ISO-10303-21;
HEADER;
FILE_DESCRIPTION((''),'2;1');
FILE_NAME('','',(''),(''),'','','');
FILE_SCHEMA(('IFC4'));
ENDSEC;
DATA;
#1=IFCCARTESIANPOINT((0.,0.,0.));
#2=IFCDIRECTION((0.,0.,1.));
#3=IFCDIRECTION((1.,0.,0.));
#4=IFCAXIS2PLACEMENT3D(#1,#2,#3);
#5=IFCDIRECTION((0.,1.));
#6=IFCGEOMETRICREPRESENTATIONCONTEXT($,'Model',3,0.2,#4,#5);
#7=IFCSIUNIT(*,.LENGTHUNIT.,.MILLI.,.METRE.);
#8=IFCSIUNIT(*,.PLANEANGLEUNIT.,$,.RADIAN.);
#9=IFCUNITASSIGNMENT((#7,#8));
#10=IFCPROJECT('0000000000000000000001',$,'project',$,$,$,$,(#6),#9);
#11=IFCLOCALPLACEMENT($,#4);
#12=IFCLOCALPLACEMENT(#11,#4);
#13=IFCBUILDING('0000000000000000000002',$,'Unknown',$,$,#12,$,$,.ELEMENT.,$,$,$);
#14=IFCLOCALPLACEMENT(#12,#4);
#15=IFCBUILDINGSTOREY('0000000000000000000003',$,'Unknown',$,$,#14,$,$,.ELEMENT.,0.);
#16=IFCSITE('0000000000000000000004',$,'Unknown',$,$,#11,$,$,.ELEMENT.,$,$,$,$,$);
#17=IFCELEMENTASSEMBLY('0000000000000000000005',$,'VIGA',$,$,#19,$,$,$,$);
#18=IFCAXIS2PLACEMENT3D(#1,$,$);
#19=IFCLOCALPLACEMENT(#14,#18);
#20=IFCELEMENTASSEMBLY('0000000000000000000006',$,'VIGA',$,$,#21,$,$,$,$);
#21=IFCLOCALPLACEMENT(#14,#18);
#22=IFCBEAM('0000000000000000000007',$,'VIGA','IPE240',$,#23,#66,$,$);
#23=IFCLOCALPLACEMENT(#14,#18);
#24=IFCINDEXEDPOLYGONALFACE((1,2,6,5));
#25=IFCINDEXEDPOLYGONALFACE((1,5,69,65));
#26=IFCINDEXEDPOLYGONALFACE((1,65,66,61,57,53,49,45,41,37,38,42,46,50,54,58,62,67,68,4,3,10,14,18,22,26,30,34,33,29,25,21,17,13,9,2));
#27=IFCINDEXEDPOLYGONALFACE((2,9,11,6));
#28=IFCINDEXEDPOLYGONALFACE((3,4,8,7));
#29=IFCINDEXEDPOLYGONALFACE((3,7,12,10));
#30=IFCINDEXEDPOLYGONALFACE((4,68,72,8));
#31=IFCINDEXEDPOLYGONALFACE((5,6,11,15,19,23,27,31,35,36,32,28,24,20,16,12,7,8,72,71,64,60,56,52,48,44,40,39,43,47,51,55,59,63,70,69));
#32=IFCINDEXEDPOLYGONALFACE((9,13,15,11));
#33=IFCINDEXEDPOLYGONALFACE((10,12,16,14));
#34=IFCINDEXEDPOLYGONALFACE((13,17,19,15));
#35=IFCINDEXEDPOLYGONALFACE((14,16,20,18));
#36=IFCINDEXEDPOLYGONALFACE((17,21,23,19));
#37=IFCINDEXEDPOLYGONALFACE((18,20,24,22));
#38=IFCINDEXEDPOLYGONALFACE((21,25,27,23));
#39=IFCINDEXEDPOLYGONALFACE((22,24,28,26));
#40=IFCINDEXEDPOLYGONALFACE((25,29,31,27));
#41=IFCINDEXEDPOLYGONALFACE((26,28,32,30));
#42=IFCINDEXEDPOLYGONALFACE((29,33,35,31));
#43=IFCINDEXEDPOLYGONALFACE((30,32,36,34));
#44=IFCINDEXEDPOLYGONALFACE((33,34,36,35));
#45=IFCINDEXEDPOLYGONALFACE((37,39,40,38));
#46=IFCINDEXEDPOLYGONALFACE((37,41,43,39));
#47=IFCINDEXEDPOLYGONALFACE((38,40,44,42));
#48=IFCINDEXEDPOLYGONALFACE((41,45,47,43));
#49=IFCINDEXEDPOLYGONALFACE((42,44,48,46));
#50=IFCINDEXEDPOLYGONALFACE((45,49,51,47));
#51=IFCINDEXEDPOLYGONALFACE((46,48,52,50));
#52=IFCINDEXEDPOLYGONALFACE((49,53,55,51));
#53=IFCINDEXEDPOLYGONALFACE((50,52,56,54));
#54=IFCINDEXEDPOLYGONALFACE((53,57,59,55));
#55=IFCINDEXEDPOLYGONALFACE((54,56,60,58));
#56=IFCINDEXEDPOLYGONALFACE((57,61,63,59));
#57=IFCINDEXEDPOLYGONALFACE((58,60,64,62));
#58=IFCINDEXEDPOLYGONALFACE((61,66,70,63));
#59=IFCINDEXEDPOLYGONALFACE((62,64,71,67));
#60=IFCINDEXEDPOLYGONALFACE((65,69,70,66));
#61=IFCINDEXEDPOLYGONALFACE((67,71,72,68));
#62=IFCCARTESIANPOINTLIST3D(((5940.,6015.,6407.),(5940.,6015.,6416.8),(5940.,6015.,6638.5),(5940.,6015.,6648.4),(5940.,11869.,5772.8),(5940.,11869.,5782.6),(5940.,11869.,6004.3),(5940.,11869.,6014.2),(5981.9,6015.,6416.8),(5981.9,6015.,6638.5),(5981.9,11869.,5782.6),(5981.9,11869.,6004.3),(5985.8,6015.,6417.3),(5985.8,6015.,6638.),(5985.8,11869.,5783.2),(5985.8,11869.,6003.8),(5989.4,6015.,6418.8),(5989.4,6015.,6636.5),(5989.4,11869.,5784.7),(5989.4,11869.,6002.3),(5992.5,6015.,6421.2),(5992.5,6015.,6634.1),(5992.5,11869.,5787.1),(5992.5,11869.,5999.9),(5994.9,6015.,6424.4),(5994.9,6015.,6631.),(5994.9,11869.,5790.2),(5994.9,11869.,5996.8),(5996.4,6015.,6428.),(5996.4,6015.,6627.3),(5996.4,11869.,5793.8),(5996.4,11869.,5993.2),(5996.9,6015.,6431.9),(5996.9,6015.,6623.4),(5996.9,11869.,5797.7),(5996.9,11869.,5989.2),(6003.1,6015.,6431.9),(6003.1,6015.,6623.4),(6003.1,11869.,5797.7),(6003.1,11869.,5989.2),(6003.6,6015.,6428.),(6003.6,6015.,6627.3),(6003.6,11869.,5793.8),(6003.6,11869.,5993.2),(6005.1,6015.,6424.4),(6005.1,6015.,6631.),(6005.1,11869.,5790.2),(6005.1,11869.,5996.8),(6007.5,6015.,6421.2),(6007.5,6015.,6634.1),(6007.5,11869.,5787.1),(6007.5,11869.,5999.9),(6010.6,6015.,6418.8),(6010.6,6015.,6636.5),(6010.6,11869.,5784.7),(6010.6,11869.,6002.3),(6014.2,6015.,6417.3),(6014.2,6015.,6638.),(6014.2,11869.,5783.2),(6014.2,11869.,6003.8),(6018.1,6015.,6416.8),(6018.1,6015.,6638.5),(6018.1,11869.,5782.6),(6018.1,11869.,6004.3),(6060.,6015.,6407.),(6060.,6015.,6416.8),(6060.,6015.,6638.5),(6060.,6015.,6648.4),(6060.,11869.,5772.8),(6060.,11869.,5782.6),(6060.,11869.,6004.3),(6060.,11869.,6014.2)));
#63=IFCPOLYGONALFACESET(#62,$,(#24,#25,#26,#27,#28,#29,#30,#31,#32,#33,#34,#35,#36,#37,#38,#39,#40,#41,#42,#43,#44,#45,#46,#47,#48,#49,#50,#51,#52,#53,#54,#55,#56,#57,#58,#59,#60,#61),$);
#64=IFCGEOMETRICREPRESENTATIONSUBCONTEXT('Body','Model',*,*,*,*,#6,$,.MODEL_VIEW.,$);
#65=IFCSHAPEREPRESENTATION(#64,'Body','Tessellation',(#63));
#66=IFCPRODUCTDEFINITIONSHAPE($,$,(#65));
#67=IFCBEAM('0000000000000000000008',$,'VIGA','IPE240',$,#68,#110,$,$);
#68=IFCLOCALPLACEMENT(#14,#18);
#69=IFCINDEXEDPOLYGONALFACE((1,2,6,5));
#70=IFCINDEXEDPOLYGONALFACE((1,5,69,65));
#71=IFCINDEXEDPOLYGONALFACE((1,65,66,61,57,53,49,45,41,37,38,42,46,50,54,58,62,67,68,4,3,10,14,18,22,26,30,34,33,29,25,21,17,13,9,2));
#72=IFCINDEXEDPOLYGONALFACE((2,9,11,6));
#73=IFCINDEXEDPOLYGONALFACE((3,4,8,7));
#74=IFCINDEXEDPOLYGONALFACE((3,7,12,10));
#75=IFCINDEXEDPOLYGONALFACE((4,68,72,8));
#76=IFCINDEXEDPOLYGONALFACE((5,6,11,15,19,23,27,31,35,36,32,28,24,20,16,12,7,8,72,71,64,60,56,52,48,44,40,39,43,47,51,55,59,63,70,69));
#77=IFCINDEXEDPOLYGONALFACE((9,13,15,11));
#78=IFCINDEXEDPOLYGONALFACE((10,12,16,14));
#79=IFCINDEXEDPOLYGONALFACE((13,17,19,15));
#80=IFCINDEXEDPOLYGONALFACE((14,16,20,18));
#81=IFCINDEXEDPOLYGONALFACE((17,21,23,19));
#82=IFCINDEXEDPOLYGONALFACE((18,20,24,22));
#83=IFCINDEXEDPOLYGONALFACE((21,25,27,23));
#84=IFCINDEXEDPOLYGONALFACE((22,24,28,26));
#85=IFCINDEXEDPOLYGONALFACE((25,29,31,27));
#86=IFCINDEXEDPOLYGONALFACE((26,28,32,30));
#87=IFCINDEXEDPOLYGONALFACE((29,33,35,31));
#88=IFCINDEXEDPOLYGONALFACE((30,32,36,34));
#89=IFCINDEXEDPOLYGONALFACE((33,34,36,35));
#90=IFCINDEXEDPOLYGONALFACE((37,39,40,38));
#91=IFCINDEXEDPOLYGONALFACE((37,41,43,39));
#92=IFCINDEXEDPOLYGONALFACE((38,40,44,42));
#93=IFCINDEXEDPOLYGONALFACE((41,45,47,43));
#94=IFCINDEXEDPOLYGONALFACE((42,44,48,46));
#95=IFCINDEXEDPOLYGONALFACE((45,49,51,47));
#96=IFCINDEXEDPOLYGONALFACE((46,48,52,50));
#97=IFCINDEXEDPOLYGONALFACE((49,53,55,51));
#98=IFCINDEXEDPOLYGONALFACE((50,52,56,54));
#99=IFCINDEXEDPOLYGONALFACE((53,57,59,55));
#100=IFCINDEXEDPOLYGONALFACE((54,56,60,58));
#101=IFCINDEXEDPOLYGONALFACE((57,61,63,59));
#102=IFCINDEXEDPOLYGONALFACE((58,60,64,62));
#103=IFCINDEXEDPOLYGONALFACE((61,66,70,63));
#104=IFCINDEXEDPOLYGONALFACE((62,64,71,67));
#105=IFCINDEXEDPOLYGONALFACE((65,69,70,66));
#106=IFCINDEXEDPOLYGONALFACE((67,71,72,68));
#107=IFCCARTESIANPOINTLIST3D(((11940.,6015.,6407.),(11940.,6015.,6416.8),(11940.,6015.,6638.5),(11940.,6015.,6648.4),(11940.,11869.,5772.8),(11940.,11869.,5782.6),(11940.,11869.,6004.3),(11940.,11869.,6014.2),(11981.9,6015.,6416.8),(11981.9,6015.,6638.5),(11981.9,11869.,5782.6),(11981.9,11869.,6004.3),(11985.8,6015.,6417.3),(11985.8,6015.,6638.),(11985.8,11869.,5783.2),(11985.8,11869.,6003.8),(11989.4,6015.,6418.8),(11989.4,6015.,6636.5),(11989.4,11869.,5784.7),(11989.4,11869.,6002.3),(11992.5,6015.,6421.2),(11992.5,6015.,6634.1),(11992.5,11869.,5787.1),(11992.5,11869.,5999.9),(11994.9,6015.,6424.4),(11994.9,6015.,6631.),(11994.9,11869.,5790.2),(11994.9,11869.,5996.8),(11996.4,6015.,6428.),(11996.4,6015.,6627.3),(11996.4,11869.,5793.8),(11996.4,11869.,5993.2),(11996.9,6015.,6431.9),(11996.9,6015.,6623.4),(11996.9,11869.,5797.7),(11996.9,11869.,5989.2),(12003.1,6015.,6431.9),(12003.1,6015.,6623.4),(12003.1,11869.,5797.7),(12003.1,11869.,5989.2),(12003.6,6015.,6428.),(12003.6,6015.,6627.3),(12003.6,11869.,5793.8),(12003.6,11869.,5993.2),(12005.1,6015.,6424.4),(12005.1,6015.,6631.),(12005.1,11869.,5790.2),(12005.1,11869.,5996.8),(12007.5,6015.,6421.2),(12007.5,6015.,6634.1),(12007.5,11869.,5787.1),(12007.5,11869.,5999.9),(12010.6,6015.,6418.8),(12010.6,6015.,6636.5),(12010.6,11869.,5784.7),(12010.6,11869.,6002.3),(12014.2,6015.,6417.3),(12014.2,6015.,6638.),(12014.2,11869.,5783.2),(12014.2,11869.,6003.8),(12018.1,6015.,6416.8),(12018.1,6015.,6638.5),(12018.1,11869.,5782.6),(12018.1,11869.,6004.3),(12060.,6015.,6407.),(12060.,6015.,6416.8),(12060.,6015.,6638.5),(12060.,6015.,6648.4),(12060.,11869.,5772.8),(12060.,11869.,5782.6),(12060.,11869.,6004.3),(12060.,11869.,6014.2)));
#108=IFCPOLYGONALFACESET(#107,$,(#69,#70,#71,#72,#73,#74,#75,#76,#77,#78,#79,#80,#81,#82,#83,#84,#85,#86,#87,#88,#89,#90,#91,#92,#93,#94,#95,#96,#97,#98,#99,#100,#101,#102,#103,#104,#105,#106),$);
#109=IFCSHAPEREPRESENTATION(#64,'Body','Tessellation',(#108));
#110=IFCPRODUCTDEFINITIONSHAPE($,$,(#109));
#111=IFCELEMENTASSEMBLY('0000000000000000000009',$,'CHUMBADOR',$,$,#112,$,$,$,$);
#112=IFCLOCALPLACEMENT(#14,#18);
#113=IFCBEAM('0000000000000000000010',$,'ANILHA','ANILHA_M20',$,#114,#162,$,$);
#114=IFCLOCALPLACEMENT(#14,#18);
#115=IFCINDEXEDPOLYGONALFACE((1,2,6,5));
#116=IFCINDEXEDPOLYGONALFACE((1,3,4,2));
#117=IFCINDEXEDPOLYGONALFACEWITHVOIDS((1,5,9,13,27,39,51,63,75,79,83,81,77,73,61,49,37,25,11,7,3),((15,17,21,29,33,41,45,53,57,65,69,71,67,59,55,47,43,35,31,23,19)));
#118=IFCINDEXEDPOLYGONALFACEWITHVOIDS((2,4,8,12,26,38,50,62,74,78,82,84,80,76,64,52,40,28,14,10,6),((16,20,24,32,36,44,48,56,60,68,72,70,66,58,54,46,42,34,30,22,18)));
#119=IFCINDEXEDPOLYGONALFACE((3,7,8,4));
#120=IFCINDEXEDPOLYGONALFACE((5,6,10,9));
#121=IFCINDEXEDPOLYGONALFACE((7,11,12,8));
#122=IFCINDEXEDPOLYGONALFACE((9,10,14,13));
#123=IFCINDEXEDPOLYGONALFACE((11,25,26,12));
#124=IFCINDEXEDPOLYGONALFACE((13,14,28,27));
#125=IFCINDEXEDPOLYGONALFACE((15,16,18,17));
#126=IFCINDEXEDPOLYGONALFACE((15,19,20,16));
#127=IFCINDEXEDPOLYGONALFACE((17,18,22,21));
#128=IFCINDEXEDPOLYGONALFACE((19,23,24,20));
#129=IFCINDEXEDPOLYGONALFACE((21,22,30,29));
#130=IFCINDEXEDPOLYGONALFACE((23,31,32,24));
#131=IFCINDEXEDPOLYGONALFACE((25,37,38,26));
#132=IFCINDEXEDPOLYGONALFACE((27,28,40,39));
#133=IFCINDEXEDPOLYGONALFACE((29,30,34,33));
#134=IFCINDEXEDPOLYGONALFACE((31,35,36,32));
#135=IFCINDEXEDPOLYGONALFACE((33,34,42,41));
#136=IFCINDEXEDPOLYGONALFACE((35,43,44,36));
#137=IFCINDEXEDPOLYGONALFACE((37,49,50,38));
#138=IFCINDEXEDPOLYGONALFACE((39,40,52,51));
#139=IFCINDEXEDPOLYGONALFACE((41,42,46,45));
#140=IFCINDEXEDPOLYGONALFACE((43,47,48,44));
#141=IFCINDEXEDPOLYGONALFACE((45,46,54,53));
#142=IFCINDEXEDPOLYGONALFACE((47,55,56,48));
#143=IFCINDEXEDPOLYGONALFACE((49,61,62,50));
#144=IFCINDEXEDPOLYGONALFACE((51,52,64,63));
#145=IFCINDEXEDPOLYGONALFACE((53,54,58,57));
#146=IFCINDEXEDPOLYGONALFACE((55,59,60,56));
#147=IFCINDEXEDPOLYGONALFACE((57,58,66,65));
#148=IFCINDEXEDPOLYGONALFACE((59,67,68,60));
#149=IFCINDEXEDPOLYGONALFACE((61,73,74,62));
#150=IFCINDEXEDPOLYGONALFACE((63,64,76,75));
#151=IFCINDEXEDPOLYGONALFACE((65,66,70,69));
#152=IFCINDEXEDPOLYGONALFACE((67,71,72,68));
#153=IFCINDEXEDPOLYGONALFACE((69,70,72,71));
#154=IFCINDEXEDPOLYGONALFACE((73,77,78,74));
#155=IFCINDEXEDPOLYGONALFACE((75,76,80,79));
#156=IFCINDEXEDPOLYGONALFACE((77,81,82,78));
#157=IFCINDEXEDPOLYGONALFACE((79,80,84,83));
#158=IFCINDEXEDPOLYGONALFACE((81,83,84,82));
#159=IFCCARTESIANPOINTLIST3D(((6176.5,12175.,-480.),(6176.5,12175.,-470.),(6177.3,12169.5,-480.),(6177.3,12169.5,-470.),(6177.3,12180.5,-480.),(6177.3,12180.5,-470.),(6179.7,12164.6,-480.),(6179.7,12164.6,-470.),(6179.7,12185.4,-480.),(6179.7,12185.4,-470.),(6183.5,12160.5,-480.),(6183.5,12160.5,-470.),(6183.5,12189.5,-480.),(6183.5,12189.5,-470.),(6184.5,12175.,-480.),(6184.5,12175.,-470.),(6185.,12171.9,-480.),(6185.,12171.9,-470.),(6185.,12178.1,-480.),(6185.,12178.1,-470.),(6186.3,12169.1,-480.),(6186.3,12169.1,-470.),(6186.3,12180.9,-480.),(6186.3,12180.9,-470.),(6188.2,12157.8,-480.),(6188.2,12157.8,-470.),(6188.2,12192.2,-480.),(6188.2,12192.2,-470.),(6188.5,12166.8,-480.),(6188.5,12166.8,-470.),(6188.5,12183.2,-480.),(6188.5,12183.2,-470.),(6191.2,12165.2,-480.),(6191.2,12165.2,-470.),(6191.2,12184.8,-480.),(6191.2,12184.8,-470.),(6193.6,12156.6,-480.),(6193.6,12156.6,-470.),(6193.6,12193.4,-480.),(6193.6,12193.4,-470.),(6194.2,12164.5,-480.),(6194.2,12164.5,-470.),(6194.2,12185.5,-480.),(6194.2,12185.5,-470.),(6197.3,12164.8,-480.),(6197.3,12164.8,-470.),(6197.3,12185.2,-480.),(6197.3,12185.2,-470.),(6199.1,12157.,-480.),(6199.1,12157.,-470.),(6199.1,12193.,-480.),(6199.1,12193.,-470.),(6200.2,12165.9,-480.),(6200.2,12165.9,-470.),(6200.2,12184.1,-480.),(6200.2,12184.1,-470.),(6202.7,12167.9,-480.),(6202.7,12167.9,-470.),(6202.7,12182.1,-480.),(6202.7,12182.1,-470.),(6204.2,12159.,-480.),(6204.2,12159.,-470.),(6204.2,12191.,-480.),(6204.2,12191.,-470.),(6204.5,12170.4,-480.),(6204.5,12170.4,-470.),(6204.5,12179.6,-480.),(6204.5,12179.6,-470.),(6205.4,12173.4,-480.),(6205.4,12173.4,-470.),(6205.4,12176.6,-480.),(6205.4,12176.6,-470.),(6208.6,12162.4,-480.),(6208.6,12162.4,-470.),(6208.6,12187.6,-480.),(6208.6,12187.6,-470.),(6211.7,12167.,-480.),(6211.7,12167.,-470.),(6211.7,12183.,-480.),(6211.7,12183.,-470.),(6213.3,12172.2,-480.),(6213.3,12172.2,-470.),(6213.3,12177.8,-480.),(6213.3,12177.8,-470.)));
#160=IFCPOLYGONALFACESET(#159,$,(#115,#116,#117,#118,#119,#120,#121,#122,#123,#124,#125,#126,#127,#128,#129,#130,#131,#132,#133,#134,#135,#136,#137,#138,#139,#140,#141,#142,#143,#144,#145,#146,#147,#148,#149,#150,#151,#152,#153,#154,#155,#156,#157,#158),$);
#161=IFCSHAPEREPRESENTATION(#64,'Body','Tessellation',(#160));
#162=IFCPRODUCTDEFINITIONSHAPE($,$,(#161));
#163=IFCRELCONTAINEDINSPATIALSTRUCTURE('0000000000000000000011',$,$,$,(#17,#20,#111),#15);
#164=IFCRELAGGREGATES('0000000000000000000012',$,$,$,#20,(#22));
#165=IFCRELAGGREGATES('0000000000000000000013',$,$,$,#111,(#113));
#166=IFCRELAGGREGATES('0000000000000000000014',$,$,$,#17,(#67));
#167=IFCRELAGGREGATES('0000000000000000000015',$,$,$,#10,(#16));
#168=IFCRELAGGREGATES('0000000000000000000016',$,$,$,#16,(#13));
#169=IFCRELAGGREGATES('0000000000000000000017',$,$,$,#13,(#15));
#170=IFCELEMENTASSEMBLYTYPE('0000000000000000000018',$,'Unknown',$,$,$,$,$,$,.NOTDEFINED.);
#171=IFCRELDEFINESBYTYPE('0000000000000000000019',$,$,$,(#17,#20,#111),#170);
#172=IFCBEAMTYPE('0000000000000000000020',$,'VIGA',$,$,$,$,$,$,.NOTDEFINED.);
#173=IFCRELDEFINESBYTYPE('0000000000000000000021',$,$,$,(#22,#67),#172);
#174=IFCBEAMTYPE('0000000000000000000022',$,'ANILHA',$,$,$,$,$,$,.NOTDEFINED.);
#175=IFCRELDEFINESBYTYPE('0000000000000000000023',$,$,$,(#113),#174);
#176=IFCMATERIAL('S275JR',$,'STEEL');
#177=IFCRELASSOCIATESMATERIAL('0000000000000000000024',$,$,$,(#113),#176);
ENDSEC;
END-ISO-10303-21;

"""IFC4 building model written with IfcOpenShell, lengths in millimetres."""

from ifc_helpers import new_model, si_unit, direction, frame, origin_with_axes, origin_2d_with_axis, place, context, subcontext, project, spatial, hollow_circle, i_section, extrude, clip, halfspace, material, material_profile, profile_set, profile_usage, type_object, element, aggregate, save


model = new_model("IFC4")

# Units and contexts
model_context = context("Model", 3, precision=0.2, world=origin_with_axes(), true_north=direction((0.0, 1.0)))
body_context = subcontext(model_context, "Body", "Model", "MODEL_VIEW")
ifc_project = project(units=[si_unit("LENGTHUNIT", "METRE", prefix="MILLI"), si_unit("PLANEANGLEUNIT", "RADIAN")], contexts=[model_context])

# Site, building, storey
site_placement = place(None, origin_with_axes())
site = spatial("IfcSite", under=ifc_project, at=site_placement, Name="Unknown", CompositionType="ELEMENT")
building_placement = place(site_placement, origin_with_axes())
building = spatial("IfcBuilding", under=site, at=building_placement, Name="Unknown", CompositionType="ELEMENT")
storey_placement = place(building_placement, origin_with_axes())
storey = spatial("IfcBuildingStorey", under=building, at=storey_placement, Name="Unknown", CompositionType="ELEMENT", Elevation=0.0)

# Shared definitions
element_assembly_type = type_object("IfcElementAssemblyType", Name="Unknown", PredefinedType="NOTDEFINED")

# Element assemblies
assembly_1_placement = place(storey_placement, frame((12000.0, 11987.1, 5880.7), z_axis=(-1.0, 0.0, 0.0), x_axis=(0.0, -0.994183, 0.107703)))
assembly_1 = element("IfcElementAssembly", 1, at=assembly_1_placement, inside=storey, type_object=element_assembly_type, Name="VIGA")
assembly_2_placement = place(storey_placement, frame((6000.0, 11987.1, 5880.7), z_axis=(-1.0, 0.0, 0.0), x_axis=(0.0, -0.994183, 0.107703)))
assembly_2 = element("IfcElementAssembly", 2, at=assembly_2_placement, inside=storey, type_object=element_assembly_type, Name="VIGA")

# Beams
beam_type_1 = type_object("IfcBeamType", Name="VIGA", PredefinedType="NOTDEFINED")
beam_1_placement = place(assembly_2_placement, origin_with_axes())
beam_1 = element("IfcBeam", 3, at=beam_1_placement, type_object=beam_type_1, Name="VIGA", Description="IPE240", context=body_context, shape_type="Clipping", body=[
    clip(clip(extrude(i_section(OverallWidth=120.0, OverallDepth=240.0, WebThickness=6.2, FlangeThickness=9.8, FilletRadius=15.0, FlangeEdgeRadius=0.0, FlangeSlope=0.0, at=origin_2d_with_axis()), frame((-121.2, 0.0, 0.0), z_axis=(-1.0, 0.0, 0.0), x_axis=(0.0, 0.0, 1.0)), (0.0, 0.0, -1.0), 6368.3), halfspace(frame((105.8, -120.0, 0.0), z_axis=(0.994183, -0.107703, 0.0), x_axis=(0.107703, 0.994183, 0.0)), True)), halfspace(frame((6021.8, 136.5, 0.0), z_axis=(-0.994183, 0.107703, 0.0), x_axis=(-0.107703, -0.994183, 0.0)), True)),
])
aggregate(assembly_2, [beam_1])
beam_2_placement = place(assembly_1_placement, origin_with_axes())
beam_2 = element("IfcBeam", 4, at=beam_2_placement, type_object=beam_type_1, Name="VIGA", Description="IPE240", context=body_context, shape_type="Clipping", body=[
    clip(clip(extrude(i_section(OverallWidth=120.0, OverallDepth=240.0, WebThickness=6.2, FlangeThickness=9.8, FilletRadius=15.0, FlangeEdgeRadius=0.0, FlangeSlope=0.0, at=origin_2d_with_axis()), frame((-121.2, 0.0, 0.0), z_axis=(-1.0, 0.0, 0.0), x_axis=(0.0, 0.0, 1.0)), (0.0, 0.0, -1.0), 6368.3), halfspace(frame((105.8, -120.0, 0.0), z_axis=(0.994183, -0.107703, 0.0), x_axis=(0.107703, 0.994183, 0.0)), True)), halfspace(frame((6021.8, 136.5, 0.0), z_axis=(-0.994183, 0.107703, 0.0), x_axis=(-0.107703, -0.994183, 0.0)), True)),
])

# Element assembly, beam
assembly_3_placement = place(storey_placement, frame((6195.0, 12175.0, -555.0), z_axis=(-1.0, 0.0, 0.0), x_axis=(0.0, 0.0, -1.0)))
assembly_3 = element("IfcElementAssembly", 5, at=assembly_3_placement, inside=storey, type_object=element_assembly_type, Name="CHUMBADOR")
ifc_material_1 = material(Name="S275JR", Category="STEEL")
ifc_material_profile_1 = material_profile(ifc_material_1, hollow_circle(Radius=18.5, WallThickness=8.0, at=origin_2d_with_axis()), Name="ANILHA_M20")
ifc_profile_set_1 = profile_set([ifc_material_profile_1])
ifc_profile_usage_1 = profile_usage(ifc_profile_set_1, cardinal=5)
beam_type_2 = type_object("IfcBeamType", Name="ANILHA", PredefinedType="NOTDEFINED")
beam_3_placement = place(assembly_3_placement, frame((-85.0, 0.0, 0.0), z_axis=(0.0, 0.0, 1.0), x_axis=(1.0, 0.0, 0.0)))
beam_3 = element("IfcBeam", 6, at=beam_3_placement, type_object=beam_type_2, material=ifc_profile_usage_1, Name="ANILHA", Description="ANILHA_M20", context=body_context, shape_type="SolidModel", body=[
    extrude(hollow_circle(Radius=18.5, WallThickness=8.0, at=origin_2d_with_axis()), frame((0.0, 0.0, 0.0), z_axis=(-1.0, 0.0, 0.0), x_axis=(0.0, 0.0, 1.0)), (0.0, 0.0, -1.0), 10.0),
])

aggregate(assembly_3, [beam_3])

aggregate(assembly_1, [beam_2])

save(model, "model.ifc")
